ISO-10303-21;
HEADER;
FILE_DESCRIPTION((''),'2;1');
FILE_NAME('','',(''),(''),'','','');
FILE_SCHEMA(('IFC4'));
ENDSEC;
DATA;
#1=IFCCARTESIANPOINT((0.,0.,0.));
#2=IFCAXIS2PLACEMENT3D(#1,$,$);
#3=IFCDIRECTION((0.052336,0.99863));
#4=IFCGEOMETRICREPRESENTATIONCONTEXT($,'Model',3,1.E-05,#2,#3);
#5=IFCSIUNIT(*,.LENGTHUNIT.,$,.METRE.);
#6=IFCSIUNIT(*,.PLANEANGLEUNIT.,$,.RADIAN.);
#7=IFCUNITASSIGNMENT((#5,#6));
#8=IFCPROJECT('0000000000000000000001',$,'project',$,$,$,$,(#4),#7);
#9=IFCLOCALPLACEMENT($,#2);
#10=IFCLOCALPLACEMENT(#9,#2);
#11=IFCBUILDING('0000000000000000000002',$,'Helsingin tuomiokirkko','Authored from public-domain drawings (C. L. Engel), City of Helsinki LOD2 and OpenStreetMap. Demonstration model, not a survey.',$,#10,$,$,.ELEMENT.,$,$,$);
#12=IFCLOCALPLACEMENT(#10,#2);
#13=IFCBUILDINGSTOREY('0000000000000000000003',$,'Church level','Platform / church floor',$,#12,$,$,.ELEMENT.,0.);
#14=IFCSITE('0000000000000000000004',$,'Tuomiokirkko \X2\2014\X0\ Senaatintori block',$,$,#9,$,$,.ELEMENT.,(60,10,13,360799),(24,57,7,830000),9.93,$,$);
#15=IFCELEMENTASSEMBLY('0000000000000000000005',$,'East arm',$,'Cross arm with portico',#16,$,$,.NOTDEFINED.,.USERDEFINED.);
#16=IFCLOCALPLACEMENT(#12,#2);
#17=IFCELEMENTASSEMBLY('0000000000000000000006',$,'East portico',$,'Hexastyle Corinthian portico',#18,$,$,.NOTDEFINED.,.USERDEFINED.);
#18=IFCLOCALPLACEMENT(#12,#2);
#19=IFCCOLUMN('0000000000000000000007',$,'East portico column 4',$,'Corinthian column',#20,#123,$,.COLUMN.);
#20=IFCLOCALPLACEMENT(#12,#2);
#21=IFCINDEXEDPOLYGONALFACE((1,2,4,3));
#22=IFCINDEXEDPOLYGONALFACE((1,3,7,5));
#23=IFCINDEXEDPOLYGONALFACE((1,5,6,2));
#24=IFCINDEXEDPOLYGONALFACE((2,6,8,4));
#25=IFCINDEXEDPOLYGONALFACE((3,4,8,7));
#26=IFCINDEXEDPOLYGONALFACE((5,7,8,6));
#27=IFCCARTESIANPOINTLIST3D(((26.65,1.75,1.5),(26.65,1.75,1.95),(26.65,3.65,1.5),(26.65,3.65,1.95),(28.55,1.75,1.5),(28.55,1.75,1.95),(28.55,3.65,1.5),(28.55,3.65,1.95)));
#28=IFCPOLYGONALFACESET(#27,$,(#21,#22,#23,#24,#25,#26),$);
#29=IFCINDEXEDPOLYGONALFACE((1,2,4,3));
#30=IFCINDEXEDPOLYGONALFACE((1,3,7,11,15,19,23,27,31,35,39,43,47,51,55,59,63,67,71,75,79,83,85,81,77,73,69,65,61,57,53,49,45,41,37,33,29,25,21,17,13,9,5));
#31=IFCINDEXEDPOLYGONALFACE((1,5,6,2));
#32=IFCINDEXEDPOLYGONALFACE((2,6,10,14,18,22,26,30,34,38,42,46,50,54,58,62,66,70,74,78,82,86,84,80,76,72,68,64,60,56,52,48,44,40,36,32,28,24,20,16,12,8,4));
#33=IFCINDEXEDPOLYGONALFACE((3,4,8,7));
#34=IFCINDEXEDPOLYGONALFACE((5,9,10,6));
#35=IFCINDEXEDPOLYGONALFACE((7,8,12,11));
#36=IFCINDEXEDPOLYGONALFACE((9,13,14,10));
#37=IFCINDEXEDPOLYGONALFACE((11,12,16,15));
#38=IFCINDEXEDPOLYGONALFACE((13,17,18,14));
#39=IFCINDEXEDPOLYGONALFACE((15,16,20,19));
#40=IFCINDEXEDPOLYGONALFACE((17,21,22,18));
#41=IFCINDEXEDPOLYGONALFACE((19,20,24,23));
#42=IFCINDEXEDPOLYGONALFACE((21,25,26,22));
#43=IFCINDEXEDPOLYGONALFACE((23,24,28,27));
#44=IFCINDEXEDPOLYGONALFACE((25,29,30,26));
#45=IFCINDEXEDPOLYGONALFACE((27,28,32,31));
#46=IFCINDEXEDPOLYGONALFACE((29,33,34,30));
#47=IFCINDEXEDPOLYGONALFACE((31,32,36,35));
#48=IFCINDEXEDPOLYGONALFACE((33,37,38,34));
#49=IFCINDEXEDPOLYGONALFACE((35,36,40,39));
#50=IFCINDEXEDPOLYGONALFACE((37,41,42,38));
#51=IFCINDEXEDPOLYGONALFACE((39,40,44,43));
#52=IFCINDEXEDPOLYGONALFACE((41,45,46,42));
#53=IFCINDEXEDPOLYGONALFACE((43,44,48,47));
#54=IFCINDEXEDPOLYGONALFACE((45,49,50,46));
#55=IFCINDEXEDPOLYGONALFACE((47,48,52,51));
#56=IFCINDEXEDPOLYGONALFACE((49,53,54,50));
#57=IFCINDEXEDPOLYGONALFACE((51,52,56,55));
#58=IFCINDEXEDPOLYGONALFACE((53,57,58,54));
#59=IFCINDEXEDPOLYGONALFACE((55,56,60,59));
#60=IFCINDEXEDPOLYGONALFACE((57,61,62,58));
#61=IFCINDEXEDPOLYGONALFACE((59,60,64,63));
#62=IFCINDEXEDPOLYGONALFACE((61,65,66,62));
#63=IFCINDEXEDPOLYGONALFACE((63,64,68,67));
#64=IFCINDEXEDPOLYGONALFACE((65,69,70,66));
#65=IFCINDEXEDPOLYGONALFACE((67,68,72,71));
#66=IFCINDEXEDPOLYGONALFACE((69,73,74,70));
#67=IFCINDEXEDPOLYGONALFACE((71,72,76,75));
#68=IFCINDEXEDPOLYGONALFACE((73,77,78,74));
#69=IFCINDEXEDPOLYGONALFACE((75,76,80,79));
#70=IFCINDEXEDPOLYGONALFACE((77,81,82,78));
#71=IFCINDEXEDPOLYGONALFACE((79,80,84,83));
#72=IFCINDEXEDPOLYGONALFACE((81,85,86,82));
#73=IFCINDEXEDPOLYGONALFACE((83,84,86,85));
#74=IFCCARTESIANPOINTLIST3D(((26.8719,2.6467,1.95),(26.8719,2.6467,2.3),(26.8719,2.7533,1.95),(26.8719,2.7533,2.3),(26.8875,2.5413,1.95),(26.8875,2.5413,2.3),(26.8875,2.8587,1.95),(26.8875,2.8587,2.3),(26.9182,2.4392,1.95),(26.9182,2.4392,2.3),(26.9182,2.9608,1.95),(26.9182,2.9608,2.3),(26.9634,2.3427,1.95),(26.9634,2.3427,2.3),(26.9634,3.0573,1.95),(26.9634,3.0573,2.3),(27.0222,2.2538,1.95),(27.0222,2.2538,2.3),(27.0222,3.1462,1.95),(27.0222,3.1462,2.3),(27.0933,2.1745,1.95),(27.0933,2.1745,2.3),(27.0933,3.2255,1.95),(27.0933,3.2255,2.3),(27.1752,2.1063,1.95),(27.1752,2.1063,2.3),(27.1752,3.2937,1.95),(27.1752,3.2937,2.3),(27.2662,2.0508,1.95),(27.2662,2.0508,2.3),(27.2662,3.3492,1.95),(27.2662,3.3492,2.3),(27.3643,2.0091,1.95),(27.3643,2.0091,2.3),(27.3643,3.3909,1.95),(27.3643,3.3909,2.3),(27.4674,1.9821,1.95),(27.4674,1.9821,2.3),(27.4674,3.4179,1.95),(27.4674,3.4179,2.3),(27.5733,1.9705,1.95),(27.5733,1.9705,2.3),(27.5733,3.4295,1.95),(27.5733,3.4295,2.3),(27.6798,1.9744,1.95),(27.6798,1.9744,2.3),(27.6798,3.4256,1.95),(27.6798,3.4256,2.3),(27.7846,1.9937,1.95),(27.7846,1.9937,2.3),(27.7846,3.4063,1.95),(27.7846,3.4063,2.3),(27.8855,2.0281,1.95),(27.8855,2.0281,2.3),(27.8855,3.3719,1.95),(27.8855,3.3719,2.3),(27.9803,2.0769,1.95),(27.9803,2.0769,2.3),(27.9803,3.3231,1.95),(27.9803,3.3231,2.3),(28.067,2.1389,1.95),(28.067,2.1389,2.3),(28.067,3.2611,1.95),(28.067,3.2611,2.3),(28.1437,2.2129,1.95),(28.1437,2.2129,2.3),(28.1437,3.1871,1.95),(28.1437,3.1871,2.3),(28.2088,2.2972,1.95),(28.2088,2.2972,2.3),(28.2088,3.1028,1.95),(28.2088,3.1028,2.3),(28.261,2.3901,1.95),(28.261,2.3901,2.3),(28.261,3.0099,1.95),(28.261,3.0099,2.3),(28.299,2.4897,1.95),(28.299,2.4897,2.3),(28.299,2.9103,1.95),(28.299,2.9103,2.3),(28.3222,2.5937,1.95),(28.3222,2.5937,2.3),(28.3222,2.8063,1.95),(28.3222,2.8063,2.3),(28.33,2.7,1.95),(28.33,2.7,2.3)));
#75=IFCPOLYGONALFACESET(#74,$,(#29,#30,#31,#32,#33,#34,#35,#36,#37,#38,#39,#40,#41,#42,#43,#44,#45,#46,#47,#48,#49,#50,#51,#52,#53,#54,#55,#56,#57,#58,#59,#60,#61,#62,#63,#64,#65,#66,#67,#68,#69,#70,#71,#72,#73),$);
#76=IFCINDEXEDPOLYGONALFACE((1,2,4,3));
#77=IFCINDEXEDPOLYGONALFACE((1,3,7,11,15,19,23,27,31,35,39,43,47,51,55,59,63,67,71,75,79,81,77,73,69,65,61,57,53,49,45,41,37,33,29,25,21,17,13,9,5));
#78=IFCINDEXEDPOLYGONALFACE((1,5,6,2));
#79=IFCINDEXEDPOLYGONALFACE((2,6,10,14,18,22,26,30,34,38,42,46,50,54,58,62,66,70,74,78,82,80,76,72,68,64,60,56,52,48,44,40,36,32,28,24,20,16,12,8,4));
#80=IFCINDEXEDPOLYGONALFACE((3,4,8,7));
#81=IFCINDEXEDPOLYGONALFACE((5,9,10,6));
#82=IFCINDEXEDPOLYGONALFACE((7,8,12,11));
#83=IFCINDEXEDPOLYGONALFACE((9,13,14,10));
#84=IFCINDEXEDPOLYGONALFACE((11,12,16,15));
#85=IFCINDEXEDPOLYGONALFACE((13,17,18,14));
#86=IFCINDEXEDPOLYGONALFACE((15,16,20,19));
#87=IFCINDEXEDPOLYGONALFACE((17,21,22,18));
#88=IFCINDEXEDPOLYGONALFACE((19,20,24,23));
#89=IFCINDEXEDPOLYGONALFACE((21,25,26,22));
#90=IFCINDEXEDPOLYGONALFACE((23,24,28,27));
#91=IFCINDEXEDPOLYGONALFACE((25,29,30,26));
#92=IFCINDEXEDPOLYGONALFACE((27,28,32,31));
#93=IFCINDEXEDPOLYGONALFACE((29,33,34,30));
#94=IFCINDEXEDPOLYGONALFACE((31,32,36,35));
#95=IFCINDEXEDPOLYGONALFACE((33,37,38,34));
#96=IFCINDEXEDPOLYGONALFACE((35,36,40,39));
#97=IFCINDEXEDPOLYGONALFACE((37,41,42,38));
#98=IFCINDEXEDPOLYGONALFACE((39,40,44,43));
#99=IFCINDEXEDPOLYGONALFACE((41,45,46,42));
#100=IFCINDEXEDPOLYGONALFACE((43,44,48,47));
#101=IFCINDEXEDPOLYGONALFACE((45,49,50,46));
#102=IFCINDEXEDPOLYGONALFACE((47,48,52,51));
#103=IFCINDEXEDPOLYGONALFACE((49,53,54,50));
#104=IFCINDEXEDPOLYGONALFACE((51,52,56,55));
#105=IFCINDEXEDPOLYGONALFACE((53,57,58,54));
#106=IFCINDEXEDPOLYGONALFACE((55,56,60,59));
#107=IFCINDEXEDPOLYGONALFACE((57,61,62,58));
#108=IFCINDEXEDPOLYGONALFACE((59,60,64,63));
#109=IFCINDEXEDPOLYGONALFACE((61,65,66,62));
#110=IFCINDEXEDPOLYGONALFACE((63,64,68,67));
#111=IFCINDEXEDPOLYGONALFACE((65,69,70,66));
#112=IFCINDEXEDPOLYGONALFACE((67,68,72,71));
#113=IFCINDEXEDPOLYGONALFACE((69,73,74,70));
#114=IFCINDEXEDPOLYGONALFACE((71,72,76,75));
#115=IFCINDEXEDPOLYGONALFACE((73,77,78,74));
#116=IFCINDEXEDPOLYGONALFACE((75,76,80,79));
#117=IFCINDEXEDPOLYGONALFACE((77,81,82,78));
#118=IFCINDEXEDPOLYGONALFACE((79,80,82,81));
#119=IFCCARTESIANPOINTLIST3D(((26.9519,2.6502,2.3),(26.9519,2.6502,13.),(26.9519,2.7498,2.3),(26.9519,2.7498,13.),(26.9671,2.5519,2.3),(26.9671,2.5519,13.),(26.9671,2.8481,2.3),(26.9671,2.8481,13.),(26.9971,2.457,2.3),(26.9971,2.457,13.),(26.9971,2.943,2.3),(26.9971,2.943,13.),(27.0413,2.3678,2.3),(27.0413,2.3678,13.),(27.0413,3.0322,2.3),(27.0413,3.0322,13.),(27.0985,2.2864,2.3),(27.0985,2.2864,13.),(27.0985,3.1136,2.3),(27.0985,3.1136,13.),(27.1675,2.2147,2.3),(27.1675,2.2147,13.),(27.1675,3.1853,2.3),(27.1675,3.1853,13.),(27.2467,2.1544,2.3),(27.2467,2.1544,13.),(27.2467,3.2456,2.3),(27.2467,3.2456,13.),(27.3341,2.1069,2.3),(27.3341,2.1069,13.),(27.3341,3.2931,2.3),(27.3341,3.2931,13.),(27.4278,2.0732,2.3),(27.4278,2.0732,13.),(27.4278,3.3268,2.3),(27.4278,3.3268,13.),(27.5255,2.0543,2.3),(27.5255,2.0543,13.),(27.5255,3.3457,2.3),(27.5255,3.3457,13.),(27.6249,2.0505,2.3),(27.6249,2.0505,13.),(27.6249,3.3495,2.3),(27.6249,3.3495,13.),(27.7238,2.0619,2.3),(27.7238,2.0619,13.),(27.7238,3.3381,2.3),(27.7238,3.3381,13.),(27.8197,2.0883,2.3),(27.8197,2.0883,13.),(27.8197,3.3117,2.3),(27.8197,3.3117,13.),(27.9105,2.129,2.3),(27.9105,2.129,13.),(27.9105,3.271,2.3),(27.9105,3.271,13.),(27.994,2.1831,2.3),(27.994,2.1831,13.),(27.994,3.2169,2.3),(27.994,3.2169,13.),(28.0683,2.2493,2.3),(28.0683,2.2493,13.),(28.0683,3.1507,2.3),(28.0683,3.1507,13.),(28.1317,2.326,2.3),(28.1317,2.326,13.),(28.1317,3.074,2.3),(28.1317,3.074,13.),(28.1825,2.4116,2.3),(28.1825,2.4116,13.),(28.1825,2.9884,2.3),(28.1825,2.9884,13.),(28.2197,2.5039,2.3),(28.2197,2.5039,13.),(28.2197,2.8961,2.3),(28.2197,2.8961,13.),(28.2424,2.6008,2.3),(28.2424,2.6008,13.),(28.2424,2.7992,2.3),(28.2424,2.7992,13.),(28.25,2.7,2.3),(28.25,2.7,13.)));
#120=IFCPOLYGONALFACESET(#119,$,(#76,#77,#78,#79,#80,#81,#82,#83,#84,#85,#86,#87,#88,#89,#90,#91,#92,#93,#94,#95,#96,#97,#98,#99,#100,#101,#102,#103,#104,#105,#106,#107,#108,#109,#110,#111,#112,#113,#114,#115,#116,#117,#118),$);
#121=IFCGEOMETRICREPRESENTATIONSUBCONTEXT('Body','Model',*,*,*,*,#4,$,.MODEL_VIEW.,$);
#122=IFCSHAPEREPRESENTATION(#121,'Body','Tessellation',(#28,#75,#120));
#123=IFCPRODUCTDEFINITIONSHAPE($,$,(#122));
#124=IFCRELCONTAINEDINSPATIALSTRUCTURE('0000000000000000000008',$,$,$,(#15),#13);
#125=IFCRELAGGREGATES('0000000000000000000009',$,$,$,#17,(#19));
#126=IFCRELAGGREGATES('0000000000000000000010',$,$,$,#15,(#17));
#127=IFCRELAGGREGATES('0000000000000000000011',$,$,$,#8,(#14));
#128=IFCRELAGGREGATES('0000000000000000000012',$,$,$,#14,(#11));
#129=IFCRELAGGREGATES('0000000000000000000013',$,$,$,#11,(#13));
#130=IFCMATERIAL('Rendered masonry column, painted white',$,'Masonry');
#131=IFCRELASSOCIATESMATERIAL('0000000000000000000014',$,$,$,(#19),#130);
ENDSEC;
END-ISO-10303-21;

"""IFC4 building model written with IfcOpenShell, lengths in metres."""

from ifc_helpers import new_model, si_unit, direction, frame, origin, origin_2d_with_axis, place, context, subcontext, project, spatial, rectangle, circle, extrude, material, element, aggregate, save


model = new_model("IFC4")

# Units and contexts
model_context = context("Model", 3, precision=1e-05, world=origin(), true_north=direction((0.052336, 0.99863)))
body_context = subcontext(model_context, "Body", "Model", "MODEL_VIEW")
ifc_project = project(units=[si_unit("LENGTHUNIT", "METRE"), si_unit("PLANEANGLEUNIT", "RADIAN")], contexts=[model_context])

# Site, building, storey
site_placement = place(None, origin())
site = spatial("IfcSite", under=ifc_project, at=site_placement, Name="Tuomiokirkko — Senaatintori block", CompositionType="ELEMENT", RefLatitude=(60, 10, 13, 360799), RefLongitude=(24, 57, 7, 830000), RefElevation=9.93)
building_placement = place(site_placement, origin())
building = spatial("IfcBuilding", under=site, at=building_placement, Name="Helsingin tuomiokirkko", Description="Authored from public-domain drawings (C. L. Engel), City of Helsinki LOD2 and OpenStreetMap. Demonstration model, not a survey.", CompositionType="ELEMENT")
storey_placement = place(building_placement, origin())
storey = spatial("IfcBuildingStorey", under=building, at=storey_placement, Name="Church level", Description="Platform / church floor", CompositionType="ELEMENT", Elevation=0.0)

# Shared definitions
ifc_material_1 = material(Name="Rendered masonry column, painted white", Category="Masonry")

# Element assemblies, column
assembly_1_placement = place(building_placement, origin())
assembly_1 = element("IfcElementAssembly", 1, at=assembly_1_placement, inside=storey, Name="East arm", ObjectType="Cross arm with portico", AssemblyPlace="NOTDEFINED", PredefinedType="USERDEFINED")
assembly_2_placement = place(building_placement, origin())
assembly_2 = element("IfcElementAssembly", 2, at=assembly_2_placement, Name="East portico", ObjectType="Hexastyle Corinthian portico", AssemblyPlace="NOTDEFINED", PredefinedType="USERDEFINED")
column_1_placement = place(building_placement, origin())
column_1 = element("IfcColumn", 3, at=column_1_placement, material=ifc_material_1, Name="East portico column 4", ObjectType="Corinthian column", PredefinedType="COLUMN", context=body_context, shape_type="SweptSolid", body=[
    extrude(rectangle(XDim=1.9, YDim=1.9, at=origin_2d_with_axis()), frame((27.6, 2.7, 1.5)), (0.0, 0.0, 1.0), 0.45),
    extrude(circle(Radius=0.73, at=origin_2d_with_axis()), frame((27.6, 2.7, 1.95)), (0.0, 0.0, 1.0), 0.35),
    extrude(circle(Radius=0.65, at=origin_2d_with_axis()), frame((27.6, 2.7, 2.3)), (0.0, 0.0, 1.0), 10.7),
])

aggregate(assembly_2, [column_1])

aggregate(assembly_1, [assembly_2])

save(model, "model.ifc")
